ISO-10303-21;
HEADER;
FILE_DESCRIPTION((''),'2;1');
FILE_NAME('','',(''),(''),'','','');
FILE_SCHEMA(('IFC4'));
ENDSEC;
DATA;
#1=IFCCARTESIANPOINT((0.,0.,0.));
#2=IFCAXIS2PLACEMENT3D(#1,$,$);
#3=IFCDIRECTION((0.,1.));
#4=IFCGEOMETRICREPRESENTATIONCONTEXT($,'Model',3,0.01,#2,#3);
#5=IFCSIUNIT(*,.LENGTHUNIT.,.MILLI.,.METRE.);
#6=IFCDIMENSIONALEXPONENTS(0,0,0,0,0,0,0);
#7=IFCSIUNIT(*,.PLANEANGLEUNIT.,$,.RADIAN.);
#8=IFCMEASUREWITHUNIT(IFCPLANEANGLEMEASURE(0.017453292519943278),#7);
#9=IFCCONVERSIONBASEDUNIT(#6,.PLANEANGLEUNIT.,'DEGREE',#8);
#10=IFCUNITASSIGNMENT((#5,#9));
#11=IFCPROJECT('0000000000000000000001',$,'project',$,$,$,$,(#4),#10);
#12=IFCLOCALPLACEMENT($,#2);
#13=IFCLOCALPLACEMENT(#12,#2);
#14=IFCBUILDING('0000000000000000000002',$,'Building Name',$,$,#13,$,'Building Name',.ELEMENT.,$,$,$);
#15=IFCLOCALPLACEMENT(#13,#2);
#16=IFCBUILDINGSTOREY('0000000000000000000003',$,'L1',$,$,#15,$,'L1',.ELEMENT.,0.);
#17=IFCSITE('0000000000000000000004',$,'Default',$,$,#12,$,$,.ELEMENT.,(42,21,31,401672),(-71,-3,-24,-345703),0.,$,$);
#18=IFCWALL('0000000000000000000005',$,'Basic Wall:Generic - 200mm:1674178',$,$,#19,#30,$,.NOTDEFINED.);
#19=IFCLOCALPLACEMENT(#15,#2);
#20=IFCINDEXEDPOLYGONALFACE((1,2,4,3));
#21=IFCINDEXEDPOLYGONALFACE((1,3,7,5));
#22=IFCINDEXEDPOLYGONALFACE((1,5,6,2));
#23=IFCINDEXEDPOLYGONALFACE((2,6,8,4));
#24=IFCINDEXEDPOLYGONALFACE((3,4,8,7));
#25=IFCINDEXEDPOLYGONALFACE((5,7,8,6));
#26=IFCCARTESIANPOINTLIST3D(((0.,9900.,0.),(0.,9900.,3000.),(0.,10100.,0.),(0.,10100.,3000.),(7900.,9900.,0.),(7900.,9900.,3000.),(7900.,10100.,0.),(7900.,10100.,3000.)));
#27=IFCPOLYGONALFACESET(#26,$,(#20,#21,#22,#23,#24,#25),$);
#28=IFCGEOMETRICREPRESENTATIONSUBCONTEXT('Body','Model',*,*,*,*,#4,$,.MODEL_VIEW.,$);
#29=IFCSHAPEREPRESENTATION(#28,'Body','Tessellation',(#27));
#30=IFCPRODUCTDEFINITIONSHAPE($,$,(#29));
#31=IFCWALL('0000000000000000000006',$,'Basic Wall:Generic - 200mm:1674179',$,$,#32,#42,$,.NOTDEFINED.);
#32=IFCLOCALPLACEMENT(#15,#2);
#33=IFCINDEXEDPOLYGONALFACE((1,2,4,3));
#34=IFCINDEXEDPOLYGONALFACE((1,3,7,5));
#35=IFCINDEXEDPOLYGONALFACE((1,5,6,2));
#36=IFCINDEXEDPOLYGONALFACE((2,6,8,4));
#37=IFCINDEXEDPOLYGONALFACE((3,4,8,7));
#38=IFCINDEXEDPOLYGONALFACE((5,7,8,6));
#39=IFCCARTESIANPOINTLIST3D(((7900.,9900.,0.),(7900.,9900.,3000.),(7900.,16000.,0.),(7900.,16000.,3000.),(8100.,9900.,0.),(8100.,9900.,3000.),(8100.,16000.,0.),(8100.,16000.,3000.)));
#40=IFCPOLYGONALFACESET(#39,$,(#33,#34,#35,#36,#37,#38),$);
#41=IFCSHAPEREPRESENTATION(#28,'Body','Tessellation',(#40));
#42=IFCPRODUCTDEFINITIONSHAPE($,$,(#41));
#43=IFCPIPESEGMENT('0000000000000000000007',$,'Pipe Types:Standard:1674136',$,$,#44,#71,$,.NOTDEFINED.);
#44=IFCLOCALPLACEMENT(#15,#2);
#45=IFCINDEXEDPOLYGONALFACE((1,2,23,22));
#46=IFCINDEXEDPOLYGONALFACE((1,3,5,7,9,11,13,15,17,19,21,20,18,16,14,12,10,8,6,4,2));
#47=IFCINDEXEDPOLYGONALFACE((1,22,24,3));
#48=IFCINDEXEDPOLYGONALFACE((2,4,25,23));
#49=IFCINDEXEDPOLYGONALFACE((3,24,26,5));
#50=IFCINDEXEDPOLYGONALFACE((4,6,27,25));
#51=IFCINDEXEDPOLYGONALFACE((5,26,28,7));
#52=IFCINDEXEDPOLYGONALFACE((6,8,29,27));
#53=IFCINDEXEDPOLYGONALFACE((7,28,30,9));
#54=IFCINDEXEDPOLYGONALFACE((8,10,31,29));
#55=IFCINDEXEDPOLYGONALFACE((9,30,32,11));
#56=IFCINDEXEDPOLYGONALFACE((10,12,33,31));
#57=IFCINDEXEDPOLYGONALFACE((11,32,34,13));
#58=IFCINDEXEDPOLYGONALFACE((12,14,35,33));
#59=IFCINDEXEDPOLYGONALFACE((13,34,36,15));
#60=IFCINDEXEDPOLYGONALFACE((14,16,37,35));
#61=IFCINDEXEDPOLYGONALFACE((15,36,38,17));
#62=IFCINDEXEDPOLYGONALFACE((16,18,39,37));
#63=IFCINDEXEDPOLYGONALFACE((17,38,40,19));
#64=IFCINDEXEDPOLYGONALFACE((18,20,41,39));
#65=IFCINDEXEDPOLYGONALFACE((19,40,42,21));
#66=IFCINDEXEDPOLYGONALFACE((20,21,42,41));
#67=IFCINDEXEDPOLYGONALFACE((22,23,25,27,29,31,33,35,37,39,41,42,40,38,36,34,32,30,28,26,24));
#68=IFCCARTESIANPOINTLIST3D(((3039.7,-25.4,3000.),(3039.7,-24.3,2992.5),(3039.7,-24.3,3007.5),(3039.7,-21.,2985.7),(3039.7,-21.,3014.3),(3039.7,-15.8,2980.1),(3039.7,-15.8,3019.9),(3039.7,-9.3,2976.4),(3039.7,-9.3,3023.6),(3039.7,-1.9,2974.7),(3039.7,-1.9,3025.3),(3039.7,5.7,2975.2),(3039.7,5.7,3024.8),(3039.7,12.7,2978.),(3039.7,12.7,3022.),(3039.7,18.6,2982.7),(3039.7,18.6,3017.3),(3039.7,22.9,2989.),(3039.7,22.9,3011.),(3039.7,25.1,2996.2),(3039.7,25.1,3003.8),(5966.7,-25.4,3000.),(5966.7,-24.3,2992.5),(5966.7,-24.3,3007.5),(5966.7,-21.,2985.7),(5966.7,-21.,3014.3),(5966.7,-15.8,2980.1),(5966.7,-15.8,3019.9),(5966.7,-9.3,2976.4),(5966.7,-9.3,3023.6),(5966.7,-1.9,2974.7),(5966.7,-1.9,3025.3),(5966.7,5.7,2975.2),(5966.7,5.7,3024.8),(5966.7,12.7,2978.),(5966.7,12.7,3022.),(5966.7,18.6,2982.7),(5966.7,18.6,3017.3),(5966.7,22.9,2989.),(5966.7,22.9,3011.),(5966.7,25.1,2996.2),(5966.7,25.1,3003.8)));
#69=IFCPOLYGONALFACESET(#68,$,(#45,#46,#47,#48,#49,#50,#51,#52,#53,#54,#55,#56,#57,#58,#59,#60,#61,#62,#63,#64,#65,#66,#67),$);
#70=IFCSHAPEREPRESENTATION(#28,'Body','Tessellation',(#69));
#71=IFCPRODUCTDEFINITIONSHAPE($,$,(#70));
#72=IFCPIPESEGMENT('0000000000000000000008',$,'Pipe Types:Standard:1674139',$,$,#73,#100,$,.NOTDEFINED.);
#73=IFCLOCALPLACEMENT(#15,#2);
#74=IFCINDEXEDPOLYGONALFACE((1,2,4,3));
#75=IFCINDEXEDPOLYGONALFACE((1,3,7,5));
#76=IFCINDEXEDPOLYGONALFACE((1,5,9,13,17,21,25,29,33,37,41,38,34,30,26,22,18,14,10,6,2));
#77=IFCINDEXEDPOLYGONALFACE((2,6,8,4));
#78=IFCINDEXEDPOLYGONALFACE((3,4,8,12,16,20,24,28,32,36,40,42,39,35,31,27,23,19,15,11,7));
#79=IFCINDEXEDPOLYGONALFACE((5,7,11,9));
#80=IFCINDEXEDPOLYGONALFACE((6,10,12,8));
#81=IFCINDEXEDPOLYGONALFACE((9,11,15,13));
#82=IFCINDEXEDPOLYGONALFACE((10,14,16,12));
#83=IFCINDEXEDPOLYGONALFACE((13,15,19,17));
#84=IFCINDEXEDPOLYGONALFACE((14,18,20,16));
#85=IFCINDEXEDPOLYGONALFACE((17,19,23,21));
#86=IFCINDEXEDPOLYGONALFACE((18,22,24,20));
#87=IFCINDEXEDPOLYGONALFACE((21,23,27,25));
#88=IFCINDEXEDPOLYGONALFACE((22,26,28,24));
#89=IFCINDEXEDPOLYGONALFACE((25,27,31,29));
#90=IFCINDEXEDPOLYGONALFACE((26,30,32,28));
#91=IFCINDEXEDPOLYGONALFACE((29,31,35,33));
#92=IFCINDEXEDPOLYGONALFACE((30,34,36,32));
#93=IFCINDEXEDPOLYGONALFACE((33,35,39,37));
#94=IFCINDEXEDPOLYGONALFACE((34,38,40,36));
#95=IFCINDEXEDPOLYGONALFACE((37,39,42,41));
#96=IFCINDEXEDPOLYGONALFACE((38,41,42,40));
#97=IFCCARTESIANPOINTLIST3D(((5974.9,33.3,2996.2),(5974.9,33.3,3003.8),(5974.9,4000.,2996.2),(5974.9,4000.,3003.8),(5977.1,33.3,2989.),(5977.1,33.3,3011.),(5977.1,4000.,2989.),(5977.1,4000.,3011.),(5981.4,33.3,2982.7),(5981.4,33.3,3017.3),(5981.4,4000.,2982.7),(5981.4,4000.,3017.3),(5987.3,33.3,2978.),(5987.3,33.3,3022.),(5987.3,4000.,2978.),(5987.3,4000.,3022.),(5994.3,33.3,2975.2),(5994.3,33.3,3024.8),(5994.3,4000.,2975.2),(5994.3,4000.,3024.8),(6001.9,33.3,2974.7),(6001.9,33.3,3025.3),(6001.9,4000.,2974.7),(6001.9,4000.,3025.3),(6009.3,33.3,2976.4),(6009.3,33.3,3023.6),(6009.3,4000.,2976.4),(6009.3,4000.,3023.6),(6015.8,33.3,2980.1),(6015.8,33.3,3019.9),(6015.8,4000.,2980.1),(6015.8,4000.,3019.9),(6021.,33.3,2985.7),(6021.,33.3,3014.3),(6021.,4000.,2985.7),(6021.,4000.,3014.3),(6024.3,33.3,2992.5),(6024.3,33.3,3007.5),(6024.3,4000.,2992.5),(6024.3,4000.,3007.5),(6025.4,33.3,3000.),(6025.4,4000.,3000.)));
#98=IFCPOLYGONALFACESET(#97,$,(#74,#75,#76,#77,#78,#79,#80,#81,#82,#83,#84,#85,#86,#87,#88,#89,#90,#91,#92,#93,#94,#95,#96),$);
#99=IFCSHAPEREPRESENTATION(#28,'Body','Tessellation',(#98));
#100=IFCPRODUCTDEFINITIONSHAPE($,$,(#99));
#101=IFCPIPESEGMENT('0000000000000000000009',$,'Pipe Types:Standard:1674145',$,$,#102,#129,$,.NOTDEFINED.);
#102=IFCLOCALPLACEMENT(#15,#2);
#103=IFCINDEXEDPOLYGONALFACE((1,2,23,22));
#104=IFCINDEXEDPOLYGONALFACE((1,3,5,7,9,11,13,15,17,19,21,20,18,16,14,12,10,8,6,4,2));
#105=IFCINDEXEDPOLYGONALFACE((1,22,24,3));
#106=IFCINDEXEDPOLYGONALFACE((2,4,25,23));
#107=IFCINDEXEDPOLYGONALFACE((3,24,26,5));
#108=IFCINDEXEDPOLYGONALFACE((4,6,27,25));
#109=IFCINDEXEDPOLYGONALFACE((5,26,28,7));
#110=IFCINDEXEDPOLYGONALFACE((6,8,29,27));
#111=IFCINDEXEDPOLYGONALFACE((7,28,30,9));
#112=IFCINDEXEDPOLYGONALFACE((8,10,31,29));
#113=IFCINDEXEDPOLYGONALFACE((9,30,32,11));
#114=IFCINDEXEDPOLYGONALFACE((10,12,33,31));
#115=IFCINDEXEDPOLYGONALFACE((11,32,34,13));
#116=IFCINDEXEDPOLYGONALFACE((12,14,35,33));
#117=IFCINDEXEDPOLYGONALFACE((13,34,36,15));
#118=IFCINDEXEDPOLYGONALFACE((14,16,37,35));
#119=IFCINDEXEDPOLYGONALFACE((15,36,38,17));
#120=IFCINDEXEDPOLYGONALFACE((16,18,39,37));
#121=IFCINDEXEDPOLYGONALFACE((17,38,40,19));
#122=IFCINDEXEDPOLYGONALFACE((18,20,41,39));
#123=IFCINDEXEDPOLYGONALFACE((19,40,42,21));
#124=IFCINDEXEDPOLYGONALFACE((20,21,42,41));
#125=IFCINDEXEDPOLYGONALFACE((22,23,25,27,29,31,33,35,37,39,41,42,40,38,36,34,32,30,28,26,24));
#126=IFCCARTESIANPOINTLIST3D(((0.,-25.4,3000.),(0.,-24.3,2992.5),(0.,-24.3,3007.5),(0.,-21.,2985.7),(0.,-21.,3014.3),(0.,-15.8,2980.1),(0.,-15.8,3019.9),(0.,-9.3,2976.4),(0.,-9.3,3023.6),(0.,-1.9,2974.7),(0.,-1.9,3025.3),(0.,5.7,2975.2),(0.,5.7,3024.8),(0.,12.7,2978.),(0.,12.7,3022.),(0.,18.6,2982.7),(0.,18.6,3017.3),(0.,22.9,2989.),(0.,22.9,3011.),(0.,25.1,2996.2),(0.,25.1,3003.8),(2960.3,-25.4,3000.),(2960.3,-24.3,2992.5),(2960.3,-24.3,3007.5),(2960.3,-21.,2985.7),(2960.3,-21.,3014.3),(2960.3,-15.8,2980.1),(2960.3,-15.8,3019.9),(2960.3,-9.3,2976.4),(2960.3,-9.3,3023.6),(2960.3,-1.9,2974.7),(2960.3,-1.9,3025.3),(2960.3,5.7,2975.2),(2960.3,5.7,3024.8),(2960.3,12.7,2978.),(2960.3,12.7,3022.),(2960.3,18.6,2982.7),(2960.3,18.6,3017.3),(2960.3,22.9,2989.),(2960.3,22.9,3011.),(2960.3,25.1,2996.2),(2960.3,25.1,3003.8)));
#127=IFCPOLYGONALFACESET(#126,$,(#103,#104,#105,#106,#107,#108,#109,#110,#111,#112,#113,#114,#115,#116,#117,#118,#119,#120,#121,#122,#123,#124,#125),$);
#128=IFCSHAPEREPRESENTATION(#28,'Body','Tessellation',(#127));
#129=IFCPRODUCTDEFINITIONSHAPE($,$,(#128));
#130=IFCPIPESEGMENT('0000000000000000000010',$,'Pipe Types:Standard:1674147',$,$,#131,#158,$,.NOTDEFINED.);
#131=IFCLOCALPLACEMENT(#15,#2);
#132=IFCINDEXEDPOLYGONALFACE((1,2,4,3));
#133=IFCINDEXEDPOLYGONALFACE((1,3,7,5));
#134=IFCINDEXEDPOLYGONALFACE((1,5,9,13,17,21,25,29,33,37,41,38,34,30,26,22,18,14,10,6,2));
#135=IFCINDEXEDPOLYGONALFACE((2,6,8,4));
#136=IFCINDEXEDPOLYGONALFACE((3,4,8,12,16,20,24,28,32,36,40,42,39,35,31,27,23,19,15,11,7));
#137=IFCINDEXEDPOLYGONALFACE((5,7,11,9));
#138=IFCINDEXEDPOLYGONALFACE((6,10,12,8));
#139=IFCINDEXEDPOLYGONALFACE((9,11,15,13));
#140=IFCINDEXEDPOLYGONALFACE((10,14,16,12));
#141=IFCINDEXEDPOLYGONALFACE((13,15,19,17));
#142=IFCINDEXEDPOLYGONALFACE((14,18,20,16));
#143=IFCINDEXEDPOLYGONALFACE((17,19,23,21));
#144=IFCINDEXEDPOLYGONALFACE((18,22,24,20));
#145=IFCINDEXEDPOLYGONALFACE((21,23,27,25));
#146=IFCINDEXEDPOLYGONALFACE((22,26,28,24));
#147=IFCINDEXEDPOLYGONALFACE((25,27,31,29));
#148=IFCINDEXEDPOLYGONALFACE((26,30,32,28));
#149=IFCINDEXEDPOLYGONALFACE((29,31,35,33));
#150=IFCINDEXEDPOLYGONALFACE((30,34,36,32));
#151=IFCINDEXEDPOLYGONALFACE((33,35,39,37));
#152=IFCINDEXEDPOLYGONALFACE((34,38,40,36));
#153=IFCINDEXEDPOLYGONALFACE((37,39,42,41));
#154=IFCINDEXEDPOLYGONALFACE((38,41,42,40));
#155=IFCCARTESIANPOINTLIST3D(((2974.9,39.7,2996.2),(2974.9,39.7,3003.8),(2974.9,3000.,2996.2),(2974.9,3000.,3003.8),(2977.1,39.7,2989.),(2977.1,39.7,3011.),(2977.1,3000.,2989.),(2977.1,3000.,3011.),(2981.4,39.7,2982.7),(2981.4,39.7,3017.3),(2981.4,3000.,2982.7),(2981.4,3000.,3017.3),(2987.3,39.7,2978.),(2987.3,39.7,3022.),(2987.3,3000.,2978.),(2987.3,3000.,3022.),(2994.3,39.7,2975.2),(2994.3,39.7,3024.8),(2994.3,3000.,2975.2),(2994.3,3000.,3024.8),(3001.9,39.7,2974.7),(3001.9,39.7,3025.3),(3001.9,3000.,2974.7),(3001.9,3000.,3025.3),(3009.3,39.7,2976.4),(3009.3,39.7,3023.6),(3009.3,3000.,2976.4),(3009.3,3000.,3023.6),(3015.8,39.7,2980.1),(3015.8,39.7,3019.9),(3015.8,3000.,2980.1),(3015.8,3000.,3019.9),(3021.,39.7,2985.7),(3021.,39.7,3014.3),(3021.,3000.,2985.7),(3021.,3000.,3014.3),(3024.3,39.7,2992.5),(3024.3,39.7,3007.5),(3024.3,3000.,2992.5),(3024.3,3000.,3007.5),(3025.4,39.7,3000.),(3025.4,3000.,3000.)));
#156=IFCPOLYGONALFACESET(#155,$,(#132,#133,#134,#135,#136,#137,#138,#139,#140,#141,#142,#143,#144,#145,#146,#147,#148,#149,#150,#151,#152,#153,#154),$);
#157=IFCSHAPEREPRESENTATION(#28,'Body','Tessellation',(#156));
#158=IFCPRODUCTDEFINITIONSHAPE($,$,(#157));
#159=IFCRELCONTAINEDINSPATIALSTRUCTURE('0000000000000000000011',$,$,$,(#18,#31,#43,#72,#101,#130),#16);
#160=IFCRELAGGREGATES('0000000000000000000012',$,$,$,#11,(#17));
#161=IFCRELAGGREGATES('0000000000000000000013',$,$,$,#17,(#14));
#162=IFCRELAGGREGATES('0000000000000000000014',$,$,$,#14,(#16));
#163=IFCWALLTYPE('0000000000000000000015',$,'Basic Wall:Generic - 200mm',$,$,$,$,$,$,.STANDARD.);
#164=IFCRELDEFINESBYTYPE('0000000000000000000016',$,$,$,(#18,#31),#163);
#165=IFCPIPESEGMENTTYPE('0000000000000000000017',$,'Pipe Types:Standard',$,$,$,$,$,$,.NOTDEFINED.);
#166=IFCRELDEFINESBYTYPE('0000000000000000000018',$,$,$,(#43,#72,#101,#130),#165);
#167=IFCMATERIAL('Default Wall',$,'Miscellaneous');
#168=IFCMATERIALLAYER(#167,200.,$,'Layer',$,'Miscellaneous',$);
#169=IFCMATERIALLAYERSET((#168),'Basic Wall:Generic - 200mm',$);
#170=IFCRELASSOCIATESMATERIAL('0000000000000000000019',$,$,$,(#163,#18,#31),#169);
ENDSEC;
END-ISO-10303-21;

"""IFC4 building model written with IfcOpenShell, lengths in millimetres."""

from ifc_helpers import new_model, entity, si_unit, converted_unit, direction, frame, frame_2d, origin, origin_2d_with_axis, place, context, subcontext, project, spatial, rectangle, circle, extrude, material, layer, layer_set, layer_usage, type_object, element, save


model = new_model("IFC4")

# Units and contexts
model_context = context("Model", 3, precision=0.01, world=origin(), true_north=direction((0.0, 1.0)))
body_context = subcontext(model_context, "Body", "Model", "MODEL_VIEW")
ifc_project = project(units=[si_unit("LENGTHUNIT", "METRE", prefix="MILLI"), converted_unit("PLANEANGLEUNIT", "DEGREE", entity("IfcPlaneAngleMeasure", 0.017453292519943278), si_unit("PLANEANGLEUNIT", "RADIAN"), dimensions=[0, 0, 0, 0, 0, 0, 0])], contexts=[model_context])

# Site, building, storey
site_placement = place(None, origin())
site = spatial("IfcSite", under=ifc_project, at=site_placement, Name="Default", CompositionType="ELEMENT", RefLatitude=(42, 21, 31, 401672), RefLongitude=(-71, -3, -24, -345703), RefElevation=0.0)
building_placement = place(site_placement, origin())
building = spatial("IfcBuilding", under=site, at=building_placement, Name="Building Name", LongName="Building Name", CompositionType="ELEMENT")
storey_placement = place(building_placement, origin())
storey = spatial("IfcBuildingStorey", under=building, at=storey_placement, Name="L1", LongName="L1", CompositionType="ELEMENT", Elevation=0.0)

# Walls
ifc_material = material(Name="Default Wall", Category="Miscellaneous")
ifc_layer = layer(ifc_material, 200.0, Name="Layer", Category="Miscellaneous")
ifc_layer_set = layer_set([ifc_layer], Name="Basic Wall:Generic - 200mm")
ifc_layer_usage_1 = layer_usage(ifc_layer_set, "AXIS2", "NEGATIVE", 100.0)
wall_type = type_object("IfcWallType", Name="Basic Wall:Generic - 200mm", PredefinedType="STANDARD", material=ifc_layer_set)
wall_1_placement = place(storey_placement, frame((0.0, 10000.0, 0.0)))
element("IfcWall", 1, at=wall_1_placement, inside=storey, type_object=wall_type, material=ifc_layer_usage_1, Name="Basic Wall:Generic - 200mm:1674178", PredefinedType="NOTDEFINED", context=body_context, shape_type="SweptSolid", body=[
    extrude(rectangle(XDim=7900.0, YDim=200.0, at=frame_2d((3950.0, 0.0), x_axis=(-1.0, 0.0))), origin(), (0.0, 0.0, 1.0), 3000.0),
])
ifc_layer_usage_2 = layer_usage(ifc_layer_set, "AXIS2", "NEGATIVE", 100.0)
wall_2_placement = place(storey_placement, frame((8000.0, 9900.0, 0.0), z_axis=(0.0, 0.0, 1.0), x_axis=(0.0, 1.0, 0.0)))
element("IfcWall", 2, at=wall_2_placement, inside=storey, type_object=wall_type, material=ifc_layer_usage_2, Name="Basic Wall:Generic - 200mm:1674179", PredefinedType="NOTDEFINED", context=body_context, shape_type="SweptSolid", body=[
    extrude(rectangle(XDim=6100.0, YDim=200.0, at=frame_2d((3050.0, 0.0), x_axis=(-1.0, 0.0))), origin(), (0.0, 0.0, 1.0), 3000.0),
])

# Pipe segments
pipe_segment_type = type_object("IfcPipeSegmentType", Name="Pipe Types:Standard", PredefinedType="NOTDEFINED")
pipe_segment_1_placement = place(storey_placement, origin())
element("IfcPipeSegment", 3, at=pipe_segment_1_placement, inside=storey, type_object=pipe_segment_type, Name="Pipe Types:Standard:1674136", PredefinedType="NOTDEFINED", context=body_context, shape_type="SweptSolid", body=[
    extrude(circle(Radius=25.4, at=frame_2d((0.0, 0.0), x_axis=(1.0, 0.0))), frame((3039.7, 0.0, 3000.0), z_axis=(1.0, 0.0, 0.0), x_axis=(0.0, -1.0, 0.0)), (0.0, 0.0, 1.0), 2927.0),
])
pipe_segment_2_placement = place(storey_placement, origin())
element("IfcPipeSegment", 4, at=pipe_segment_2_placement, inside=storey, type_object=pipe_segment_type, Name="Pipe Types:Standard:1674139", PredefinedType="NOTDEFINED", context=body_context, shape_type="SweptSolid", body=[
    extrude(circle(Radius=25.4, at=origin_2d_with_axis()), frame((6000.0, 33.3, 3000.0), z_axis=(0.0, 1.0, 0.0), x_axis=(1.0, 0.0, 0.0)), (0.0, 0.0, 1.0), 3966.7),
])
pipe_segment_3_placement = place(storey_placement, origin())
element("IfcPipeSegment", 5, at=pipe_segment_3_placement, inside=storey, type_object=pipe_segment_type, Name="Pipe Types:Standard:1674145", PredefinedType="NOTDEFINED", context=body_context, shape_type="SweptSolid", body=[
    extrude(circle(Radius=25.4, at=frame_2d((0.0, 0.0), x_axis=(1.0, 0.0))), frame((0.0, 0.0, 3000.0), z_axis=(1.0, 0.0, 0.0), x_axis=(0.0, -1.0, 0.0)), (0.0, 0.0, 1.0), 2960.3),
])
pipe_segment_4_placement = place(storey_placement, origin())
element("IfcPipeSegment", 6, at=pipe_segment_4_placement, inside=storey, type_object=pipe_segment_type, Name="Pipe Types:Standard:1674147", PredefinedType="NOTDEFINED", context=body_context, shape_type="SweptSolid", body=[
    extrude(circle(Radius=25.4, at=origin_2d_with_axis()), frame((3000.0, 39.7, 3000.0), z_axis=(0.0, 1.0, 0.0), x_axis=(1.0, 0.0, 0.0)), (0.0, 0.0, 1.0), 2960.3),
])

save(model, "model.ifc")
